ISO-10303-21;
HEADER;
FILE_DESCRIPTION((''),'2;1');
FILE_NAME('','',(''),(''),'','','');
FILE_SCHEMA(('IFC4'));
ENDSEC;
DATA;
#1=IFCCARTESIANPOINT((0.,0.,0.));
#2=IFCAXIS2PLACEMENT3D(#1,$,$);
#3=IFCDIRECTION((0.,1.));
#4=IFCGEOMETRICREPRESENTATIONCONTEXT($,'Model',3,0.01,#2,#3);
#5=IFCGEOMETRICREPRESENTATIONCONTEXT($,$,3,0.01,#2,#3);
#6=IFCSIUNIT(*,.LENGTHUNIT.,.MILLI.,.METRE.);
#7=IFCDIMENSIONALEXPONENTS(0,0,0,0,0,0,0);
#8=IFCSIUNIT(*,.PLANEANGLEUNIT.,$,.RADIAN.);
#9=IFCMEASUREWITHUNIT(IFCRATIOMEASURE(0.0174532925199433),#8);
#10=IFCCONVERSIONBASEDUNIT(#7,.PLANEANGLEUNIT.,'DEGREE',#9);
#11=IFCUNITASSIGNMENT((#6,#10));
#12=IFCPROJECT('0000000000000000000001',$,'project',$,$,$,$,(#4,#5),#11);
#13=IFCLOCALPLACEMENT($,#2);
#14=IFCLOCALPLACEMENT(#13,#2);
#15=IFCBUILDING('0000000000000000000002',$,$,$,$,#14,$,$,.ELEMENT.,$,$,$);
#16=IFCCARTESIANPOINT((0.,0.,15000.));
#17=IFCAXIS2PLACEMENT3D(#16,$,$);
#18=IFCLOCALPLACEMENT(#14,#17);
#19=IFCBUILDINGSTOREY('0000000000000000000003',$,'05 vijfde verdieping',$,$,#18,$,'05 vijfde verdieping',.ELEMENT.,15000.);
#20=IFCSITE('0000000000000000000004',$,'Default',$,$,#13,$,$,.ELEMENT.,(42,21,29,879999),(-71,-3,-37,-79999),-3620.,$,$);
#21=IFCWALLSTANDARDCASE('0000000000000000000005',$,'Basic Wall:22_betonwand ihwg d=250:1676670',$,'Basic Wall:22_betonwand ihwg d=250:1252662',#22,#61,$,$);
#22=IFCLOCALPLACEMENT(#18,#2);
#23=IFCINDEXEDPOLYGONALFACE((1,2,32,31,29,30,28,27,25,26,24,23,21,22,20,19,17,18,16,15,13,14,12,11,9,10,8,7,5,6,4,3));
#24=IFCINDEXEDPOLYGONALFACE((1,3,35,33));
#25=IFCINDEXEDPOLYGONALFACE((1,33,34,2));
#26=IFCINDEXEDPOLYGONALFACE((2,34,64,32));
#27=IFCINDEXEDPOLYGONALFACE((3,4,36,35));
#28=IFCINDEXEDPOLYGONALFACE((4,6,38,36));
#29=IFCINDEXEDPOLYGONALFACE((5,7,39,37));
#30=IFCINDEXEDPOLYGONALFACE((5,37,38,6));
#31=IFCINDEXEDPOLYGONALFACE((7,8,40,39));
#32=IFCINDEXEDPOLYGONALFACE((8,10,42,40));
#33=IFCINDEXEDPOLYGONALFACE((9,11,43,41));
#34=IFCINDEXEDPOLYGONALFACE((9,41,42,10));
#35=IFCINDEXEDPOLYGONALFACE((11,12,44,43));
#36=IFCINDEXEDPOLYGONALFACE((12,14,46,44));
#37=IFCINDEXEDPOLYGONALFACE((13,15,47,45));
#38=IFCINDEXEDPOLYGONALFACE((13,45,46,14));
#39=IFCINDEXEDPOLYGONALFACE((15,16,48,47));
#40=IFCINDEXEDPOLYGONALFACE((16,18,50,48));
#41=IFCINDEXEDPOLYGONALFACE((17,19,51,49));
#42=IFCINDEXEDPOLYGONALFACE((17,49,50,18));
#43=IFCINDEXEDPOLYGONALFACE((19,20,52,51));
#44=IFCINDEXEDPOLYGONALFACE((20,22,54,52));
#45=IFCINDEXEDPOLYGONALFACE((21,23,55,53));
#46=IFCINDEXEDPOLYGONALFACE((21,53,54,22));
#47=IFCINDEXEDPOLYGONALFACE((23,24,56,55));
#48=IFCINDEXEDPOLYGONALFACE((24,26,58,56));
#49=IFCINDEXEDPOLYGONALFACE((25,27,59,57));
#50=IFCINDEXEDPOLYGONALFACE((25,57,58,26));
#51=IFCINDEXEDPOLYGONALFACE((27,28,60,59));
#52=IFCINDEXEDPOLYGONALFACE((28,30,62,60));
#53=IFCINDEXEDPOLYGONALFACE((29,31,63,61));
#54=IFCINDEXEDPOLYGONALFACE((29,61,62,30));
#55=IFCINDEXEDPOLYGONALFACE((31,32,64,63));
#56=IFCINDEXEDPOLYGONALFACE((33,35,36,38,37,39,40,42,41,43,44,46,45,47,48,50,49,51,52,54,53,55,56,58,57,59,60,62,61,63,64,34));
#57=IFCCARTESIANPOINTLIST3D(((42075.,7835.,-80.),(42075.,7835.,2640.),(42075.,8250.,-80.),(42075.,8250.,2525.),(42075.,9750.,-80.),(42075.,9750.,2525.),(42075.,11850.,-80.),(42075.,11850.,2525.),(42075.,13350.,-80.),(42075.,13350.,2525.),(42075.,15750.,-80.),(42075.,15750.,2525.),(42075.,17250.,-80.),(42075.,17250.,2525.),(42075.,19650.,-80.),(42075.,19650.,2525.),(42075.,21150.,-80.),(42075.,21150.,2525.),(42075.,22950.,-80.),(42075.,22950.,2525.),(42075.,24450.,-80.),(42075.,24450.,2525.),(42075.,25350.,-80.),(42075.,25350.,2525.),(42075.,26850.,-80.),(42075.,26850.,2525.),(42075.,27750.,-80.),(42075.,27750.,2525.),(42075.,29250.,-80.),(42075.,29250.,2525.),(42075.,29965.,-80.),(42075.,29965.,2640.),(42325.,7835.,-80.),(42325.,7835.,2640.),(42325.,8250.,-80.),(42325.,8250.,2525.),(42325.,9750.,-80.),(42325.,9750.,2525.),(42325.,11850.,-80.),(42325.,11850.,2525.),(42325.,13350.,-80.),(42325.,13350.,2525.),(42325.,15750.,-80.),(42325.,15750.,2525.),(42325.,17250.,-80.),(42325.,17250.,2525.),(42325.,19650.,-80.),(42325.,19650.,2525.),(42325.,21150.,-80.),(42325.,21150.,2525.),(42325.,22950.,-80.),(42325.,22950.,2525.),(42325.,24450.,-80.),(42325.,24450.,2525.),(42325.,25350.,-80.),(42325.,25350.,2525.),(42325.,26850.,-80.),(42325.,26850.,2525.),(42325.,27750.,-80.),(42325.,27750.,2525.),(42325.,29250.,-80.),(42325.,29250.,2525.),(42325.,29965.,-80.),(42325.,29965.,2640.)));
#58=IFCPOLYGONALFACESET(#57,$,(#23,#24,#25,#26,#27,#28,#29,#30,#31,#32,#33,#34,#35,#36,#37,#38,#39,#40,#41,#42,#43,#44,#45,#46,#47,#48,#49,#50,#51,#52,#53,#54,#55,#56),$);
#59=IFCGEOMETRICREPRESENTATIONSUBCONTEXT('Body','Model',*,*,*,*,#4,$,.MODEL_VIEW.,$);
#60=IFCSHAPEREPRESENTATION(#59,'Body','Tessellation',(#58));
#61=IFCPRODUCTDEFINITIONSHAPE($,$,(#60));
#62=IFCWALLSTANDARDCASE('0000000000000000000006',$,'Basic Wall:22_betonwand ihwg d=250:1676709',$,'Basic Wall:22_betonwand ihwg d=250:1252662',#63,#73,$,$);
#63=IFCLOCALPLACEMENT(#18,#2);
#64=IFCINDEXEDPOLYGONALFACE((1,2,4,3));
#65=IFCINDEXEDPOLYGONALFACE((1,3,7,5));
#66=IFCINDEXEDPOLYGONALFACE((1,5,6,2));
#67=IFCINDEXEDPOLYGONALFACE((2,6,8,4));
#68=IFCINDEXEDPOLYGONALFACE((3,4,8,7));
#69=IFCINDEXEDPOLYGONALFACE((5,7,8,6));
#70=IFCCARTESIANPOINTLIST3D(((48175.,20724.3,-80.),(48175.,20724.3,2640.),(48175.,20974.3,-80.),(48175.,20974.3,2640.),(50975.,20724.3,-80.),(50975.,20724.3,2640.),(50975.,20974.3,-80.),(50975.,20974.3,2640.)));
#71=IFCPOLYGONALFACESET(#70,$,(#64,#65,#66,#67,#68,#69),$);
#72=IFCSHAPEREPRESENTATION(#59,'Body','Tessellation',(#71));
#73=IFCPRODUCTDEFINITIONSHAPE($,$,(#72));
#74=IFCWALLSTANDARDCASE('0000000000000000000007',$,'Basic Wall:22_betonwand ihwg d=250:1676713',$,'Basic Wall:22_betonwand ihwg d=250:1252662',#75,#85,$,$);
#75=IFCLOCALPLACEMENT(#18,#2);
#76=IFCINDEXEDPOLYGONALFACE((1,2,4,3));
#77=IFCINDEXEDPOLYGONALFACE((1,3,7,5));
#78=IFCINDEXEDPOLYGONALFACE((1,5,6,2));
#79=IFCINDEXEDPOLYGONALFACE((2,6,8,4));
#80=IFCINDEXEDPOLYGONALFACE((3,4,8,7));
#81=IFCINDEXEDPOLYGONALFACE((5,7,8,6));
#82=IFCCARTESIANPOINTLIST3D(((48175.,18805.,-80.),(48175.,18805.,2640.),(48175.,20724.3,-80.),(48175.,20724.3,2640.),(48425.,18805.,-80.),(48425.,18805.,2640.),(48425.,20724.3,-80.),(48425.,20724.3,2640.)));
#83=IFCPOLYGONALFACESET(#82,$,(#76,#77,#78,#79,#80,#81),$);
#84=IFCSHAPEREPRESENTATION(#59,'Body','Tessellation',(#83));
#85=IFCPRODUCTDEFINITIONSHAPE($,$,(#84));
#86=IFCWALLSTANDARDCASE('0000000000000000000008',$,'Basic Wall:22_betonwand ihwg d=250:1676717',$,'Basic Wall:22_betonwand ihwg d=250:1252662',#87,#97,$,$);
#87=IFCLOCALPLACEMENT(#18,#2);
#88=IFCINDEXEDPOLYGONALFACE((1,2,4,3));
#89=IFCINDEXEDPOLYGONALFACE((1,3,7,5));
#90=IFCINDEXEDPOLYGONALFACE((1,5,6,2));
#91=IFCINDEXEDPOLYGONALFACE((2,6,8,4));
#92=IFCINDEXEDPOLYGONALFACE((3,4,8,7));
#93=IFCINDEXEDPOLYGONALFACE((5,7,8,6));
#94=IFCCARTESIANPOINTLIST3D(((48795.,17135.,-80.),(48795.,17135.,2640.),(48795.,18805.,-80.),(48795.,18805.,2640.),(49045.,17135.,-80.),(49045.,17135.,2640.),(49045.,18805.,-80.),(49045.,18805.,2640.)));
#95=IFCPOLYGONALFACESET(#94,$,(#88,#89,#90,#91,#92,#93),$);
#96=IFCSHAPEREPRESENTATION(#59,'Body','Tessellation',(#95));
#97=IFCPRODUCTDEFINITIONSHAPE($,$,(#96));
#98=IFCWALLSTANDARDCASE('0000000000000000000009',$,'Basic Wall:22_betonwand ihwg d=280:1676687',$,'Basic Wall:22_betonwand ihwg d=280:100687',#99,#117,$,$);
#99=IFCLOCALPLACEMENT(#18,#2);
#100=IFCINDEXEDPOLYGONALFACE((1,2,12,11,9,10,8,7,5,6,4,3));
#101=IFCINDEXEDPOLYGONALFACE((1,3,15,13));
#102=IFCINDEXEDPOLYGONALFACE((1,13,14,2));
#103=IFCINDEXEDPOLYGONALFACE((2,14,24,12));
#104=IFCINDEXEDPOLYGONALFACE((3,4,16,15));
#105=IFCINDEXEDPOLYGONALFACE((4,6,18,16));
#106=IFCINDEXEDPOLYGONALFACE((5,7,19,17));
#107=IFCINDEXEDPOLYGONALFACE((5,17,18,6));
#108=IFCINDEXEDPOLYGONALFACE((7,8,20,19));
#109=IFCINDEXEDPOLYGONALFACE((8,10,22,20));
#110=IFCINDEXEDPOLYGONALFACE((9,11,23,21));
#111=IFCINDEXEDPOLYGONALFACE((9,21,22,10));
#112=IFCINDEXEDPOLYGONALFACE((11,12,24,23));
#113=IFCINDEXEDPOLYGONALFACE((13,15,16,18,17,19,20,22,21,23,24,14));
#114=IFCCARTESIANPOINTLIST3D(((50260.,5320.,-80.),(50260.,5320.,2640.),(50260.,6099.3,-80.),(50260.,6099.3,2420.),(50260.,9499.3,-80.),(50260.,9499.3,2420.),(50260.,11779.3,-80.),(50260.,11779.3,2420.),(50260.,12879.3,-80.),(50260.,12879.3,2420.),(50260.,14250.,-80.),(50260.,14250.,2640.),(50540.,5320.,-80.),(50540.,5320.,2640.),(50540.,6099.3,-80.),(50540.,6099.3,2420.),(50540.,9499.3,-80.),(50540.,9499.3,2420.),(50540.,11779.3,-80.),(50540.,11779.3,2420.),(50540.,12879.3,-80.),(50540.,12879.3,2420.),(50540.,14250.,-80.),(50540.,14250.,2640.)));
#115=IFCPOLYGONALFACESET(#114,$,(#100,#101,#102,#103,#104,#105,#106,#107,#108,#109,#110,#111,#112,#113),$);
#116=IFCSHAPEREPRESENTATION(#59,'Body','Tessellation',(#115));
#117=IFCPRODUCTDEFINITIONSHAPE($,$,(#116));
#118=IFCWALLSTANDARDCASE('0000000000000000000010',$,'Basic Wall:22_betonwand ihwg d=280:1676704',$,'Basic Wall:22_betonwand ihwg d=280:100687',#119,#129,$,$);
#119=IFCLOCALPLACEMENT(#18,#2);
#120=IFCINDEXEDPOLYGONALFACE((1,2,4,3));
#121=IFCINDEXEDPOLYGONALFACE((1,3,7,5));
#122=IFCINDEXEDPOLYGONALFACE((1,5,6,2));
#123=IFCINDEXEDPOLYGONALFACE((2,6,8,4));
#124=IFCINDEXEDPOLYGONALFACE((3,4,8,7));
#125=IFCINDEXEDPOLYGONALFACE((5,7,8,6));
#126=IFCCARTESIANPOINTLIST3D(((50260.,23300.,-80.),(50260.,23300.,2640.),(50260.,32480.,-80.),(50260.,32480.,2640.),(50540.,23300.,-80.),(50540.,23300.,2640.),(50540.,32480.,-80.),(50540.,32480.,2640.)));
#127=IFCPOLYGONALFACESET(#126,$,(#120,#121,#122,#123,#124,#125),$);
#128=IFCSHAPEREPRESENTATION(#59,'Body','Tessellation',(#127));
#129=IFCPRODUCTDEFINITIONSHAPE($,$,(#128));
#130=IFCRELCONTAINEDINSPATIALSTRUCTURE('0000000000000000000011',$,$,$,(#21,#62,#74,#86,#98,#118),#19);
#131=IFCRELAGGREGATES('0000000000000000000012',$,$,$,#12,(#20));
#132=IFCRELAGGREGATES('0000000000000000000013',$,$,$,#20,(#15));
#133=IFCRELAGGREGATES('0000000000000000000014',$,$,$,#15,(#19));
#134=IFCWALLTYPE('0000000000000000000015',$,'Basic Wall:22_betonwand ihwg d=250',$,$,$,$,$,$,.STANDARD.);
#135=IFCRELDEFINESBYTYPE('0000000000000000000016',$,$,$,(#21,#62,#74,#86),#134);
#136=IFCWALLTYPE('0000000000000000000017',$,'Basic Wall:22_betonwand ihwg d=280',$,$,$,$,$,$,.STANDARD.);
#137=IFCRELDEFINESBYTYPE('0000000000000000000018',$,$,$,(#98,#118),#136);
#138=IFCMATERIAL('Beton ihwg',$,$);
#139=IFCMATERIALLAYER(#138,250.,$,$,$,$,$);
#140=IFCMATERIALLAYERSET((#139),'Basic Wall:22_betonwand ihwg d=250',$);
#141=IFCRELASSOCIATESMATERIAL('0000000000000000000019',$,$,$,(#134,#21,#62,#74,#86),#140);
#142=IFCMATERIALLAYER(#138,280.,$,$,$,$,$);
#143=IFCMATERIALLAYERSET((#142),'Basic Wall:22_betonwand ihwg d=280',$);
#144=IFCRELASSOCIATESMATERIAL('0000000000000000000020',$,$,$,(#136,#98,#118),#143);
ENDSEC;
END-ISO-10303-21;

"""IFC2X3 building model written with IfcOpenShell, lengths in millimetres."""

from ifc_helpers import new_model, entity, si_unit, converted_unit, direction, frame, frame_2d, origin, place, context, subcontext, project, spatial, rectangle, extrude, material, layer, layer_set, layer_usage, type_object, element, save


model = new_model("IFC2X3")

# Units and contexts
model_context = context("Model", 3, precision=0.01, world=origin(), true_north=direction((0.0, 1.0)))
context_of_model = context(None, 3, precision=0.01, world=origin(), true_north=direction((0.0, 1.0)))
body_context = subcontext(model_context, "Body", "Model", "MODEL_VIEW")
ifc_project = project(units=[si_unit("LENGTHUNIT", "METRE", prefix="MILLI"), converted_unit("PLANEANGLEUNIT", "DEGREE", entity("IfcRatioMeasure", 0.0174532925199433), si_unit("PLANEANGLEUNIT", "RADIAN"), dimensions=[0, 0, 0, 0, 0, 0, 0])], contexts=[model_context, context_of_model])

# Site, building, storey
site_placement = place(None, origin())
site = spatial("IfcSite", under=ifc_project, at=site_placement, Name="Default", CompositionType="ELEMENT", RefLatitude=(42, 21, 29, 879999), RefLongitude=(-71, -3, -37, -79999), RefElevation=-3620.0)
building_placement = place(site_placement, origin())
building = spatial("IfcBuilding", under=site, at=building_placement, CompositionType="ELEMENT")
storey_placement = place(building_placement, frame((0.0, 0.0, 15000.0)))
storey = spatial("IfcBuildingStorey", under=building, at=storey_placement, Name="05 vijfde verdieping", LongName="05 vijfde verdieping", CompositionType="ELEMENT", Elevation=15000.0)

# Shared definitions
ifc_material_1 = material(Name="Beton ihwg")

# Wall, openings
ifc_layer_1 = layer(ifc_material_1, 250.0)
ifc_layer_set_1 = layer_set([ifc_layer_1], Name="Basic Wall:22_betonwand ihwg d=250")
ifc_layer_usage_1 = layer_usage(ifc_layer_set_1, "AXIS2", "POSITIVE", -125.0)
wall_type_1 = type_object("IfcWallType", Name="Basic Wall:22_betonwand ihwg d=250", PredefinedType="STANDARD", material=ifc_layer_set_1)
wall_1_placement = place(storey_placement, frame((42200.0, 29965.0, -80.0), z_axis=(0.0, 0.0, 1.0), x_axis=(0.0, -1.0, 0.0)))
wall_1 = element("IfcWallStandardCase", 1, at=wall_1_placement, inside=storey, type_object=wall_type_1, material=ifc_layer_usage_1, Name="Basic Wall:22_betonwand ihwg d=250:1676670", ObjectType="Basic Wall:22_betonwand ihwg d=250:1252662", context=body_context, shape_type="SweptSolid", body=[
    extrude(rectangle(XDim=22130.0, YDim=250.0, at=frame_2d((11065.0, 0.0), x_axis=(-1.0, 0.0))), origin(), (0.0, 0.0, 1.0), 2720.0),
])
opening_1_placement = place(wall_1_placement, frame((29965.0, -42200.0, 80.0), z_axis=(0.0, 0.0, 1.0), x_axis=(0.0, 1.0, 0.0)))
element("IfcOpeningElement", 2, at=opening_1_placement, cuts=wall_1, ObjectType="Opening", context=body_context, shape_type="SweptSolid", body=[
    extrude(rectangle(XDim=2605.0, YDim=1500.0, at=frame_2d((0.0, 0.0), x_axis=(1.0, 0.0))), frame((40801.0, 28500.0, 1222.5), z_axis=(1.0, 0.0, 0.0), x_axis=(0.0, 0.0, -1.0)), (0.0, 0.0, 1.0), 3048.0),
])
opening_2_placement = place(wall_1_placement, frame((29965.0, -42200.0, 80.0), z_axis=(0.0, 0.0, 1.0), x_axis=(0.0, 1.0, 0.0)))
element("IfcOpeningElement", 3, at=opening_2_placement, cuts=wall_1, ObjectType="Opening", context=body_context, shape_type="SweptSolid", body=[
    extrude(rectangle(XDim=2605.0, YDim=1500.0, at=frame_2d((0.0, 0.0), x_axis=(1.0, 0.0))), frame((40801.0, 26100.0, 1222.5), z_axis=(1.0, 0.0, 0.0), x_axis=(0.0, 0.0, -1.0)), (0.0, 0.0, 1.0), 3048.0),
])
opening_3_placement = place(wall_1_placement, frame((29965.0, -42200.0, 80.0), z_axis=(0.0, 0.0, 1.0), x_axis=(0.0, 1.0, 0.0)))
element("IfcOpeningElement", 4, at=opening_3_placement, cuts=wall_1, ObjectType="Opening", context=body_context, shape_type="SweptSolid", body=[
    extrude(rectangle(XDim=2605.0, YDim=1500.0, at=frame_2d((0.0, 0.0), x_axis=(1.0, 0.0))), frame((40801.0, 23700.0, 1222.5), z_axis=(1.0, 0.0, 0.0), x_axis=(0.0, 0.0, -1.0)), (0.0, 0.0, 1.0), 3048.0),
])
opening_4_placement = place(wall_1_placement, frame((29965.0, -42200.0, 80.0), z_axis=(0.0, 0.0, 1.0), x_axis=(0.0, 1.0, 0.0)))
element("IfcOpeningElement", 5, at=opening_4_placement, cuts=wall_1, ObjectType="Opening", context=body_context, shape_type="SweptSolid", body=[
    extrude(rectangle(XDim=2605.0, YDim=1500.0, at=frame_2d((0.0, 0.0), x_axis=(1.0, 0.0))), frame((40801.0, 20400.0, 1222.5), z_axis=(1.0, 0.0, 0.0), x_axis=(0.0, 0.0, -1.0)), (0.0, 0.0, 1.0), 3048.0),
])
opening_5_placement = place(wall_1_placement, frame((29965.0, -42200.0, 80.0), z_axis=(0.0, 0.0, 1.0), x_axis=(0.0, 1.0, 0.0)))
element("IfcOpeningElement", 6, at=opening_5_placement, cuts=wall_1, ObjectType="Opening", context=body_context, shape_type="SweptSolid", body=[
    extrude(rectangle(XDim=2605.0, YDim=1500.0, at=frame_2d((0.0, 0.0), x_axis=(1.0, 0.0))), frame((40801.0, 12600.0, 1222.5), z_axis=(1.0, 0.0, 0.0), x_axis=(0.0, 0.0, -1.0)), (0.0, 0.0, 1.0), 3048.0),
])
opening_6_placement = place(wall_1_placement, frame((29965.0, -42200.0, -2920.0), z_axis=(0.0, 0.0, 1.0), x_axis=(0.0, 1.0, 0.0)))
element("IfcOpeningElement", 7, at=opening_6_placement, cuts=wall_1, ObjectType="Opening", context=body_context, shape_type="SweptSolid", body=[
    extrude(rectangle(XDim=2605.0, YDim=1500.0, at=frame_2d((0.0, 0.0), x_axis=(1.0, 0.0))), frame((40801.0, 9000.0, 4222.5), z_axis=(1.0, 0.0, 0.0), x_axis=(0.0, 0.0, -1.0)), (0.0, 0.0, 1.0), 3048.0),
])
opening_7_placement = place(wall_1_placement, frame((29965.0, -42200.0, 80.0), z_axis=(0.0, 0.0, 1.0), x_axis=(0.0, 1.0, 0.0)))
element("IfcOpeningElement", 8, at=opening_7_placement, cuts=wall_1, ObjectType="Opening", context=body_context, shape_type="SweptSolid", body=[
    extrude(rectangle(XDim=2605.0, YDim=1500.0, at=frame_2d((0.0, 0.0), x_axis=(0.0, 1.0))), frame((40551.0, 16500.0, 1222.5), z_axis=(1.0, 0.0, 0.0), x_axis=(0.0, -1.0, 0.0)), (0.0, 0.0, 1.0), 3048.0),
])

# Walls
ifc_layer_usage_2 = layer_usage(ifc_layer_set_1, "AXIS2", "POSITIVE", -125.0)
wall_2_placement = place(storey_placement, frame((50975.0, 20849.3, -80.0), z_axis=(0.0, 0.0, 1.0), x_axis=(-1.0, 0.0, 0.0)))
element("IfcWallStandardCase", 9, at=wall_2_placement, inside=storey, type_object=wall_type_1, material=ifc_layer_usage_2, Name="Basic Wall:22_betonwand ihwg d=250:1676709", ObjectType="Basic Wall:22_betonwand ihwg d=250:1252662", context=body_context, shape_type="SweptSolid", body=[
    extrude(rectangle(XDim=2800.0, YDim=250.0, at=frame_2d((1400.0, 0.0), x_axis=(-1.0, 0.0))), origin(), (0.0, 0.0, 1.0), 2720.0),
])
ifc_layer_usage_3 = layer_usage(ifc_layer_set_1, "AXIS2", "POSITIVE", -125.0)
wall_3_placement = place(storey_placement, frame((48300.0, 20724.3, -80.0), z_axis=(0.0, 0.0, 1.0), x_axis=(0.0, -1.0, 0.0)))
element("IfcWallStandardCase", 10, at=wall_3_placement, inside=storey, type_object=wall_type_1, material=ifc_layer_usage_3, Name="Basic Wall:22_betonwand ihwg d=250:1676713", ObjectType="Basic Wall:22_betonwand ihwg d=250:1252662", context=body_context, shape_type="SweptSolid", body=[
    extrude(rectangle(XDim=1919.3, YDim=250.0, at=frame_2d((959.6, 0.0), x_axis=(-1.0, 0.0))), origin(), (0.0, 0.0, 1.0), 2720.0),
])
ifc_layer_usage_4 = layer_usage(ifc_layer_set_1, "AXIS2", "POSITIVE", -125.0)
wall_4_placement = place(storey_placement, frame((48920.0, 18805.0, -80.0), z_axis=(0.0, 0.0, 1.0), x_axis=(0.0, -1.0, 0.0)))
element("IfcWallStandardCase", 11, at=wall_4_placement, inside=storey, type_object=wall_type_1, material=ifc_layer_usage_4, Name="Basic Wall:22_betonwand ihwg d=250:1676717", ObjectType="Basic Wall:22_betonwand ihwg d=250:1252662", context=body_context, shape_type="SweptSolid", body=[
    extrude(rectangle(XDim=1670.0, YDim=250.0, at=frame_2d((835.0, 0.0), x_axis=(-1.0, 0.0))), origin(), (0.0, 0.0, 1.0), 2720.0),
])

# Wall, openings
ifc_layer_2 = layer(ifc_material_1, 280.0)
ifc_layer_set_2 = layer_set([ifc_layer_2], Name="Basic Wall:22_betonwand ihwg d=280")
ifc_layer_usage_5 = layer_usage(ifc_layer_set_2, "AXIS2", "NEGATIVE", 140.0)
wall_type_2 = type_object("IfcWallType", Name="Basic Wall:22_betonwand ihwg d=280", PredefinedType="STANDARD", material=ifc_layer_set_2)
wall_5_placement = place(storey_placement, frame((50400.0, 14250.0, -80.0), z_axis=(0.0, 0.0, 1.0), x_axis=(0.0, -1.0, 0.0)))
wall_5 = element("IfcWallStandardCase", 12, at=wall_5_placement, inside=storey, type_object=wall_type_2, material=ifc_layer_usage_5, Name="Basic Wall:22_betonwand ihwg d=280:1676687", ObjectType="Basic Wall:22_betonwand ihwg d=280:100687", context=body_context, shape_type="SweptSolid", body=[
    extrude(rectangle(XDim=8930.0, YDim=280.0, at=frame_2d((4465.0, 0.0), x_axis=(-1.0, 0.0))), origin(), (0.0, 0.0, 1.0), 2720.0),
])
opening_8_placement = place(wall_5_placement, frame((14250.0, -50400.0, 80.0), z_axis=(0.0, 0.0, 1.0), x_axis=(0.0, 1.0, 0.0)))
element("IfcOpeningElement", 13, at=opening_8_placement, cuts=wall_5, ObjectType="Opening", context=body_context, shape_type="SweptSolid", body=[
    extrude(rectangle(XDim=2500.0, YDim=3400.0, at=frame_2d((0.0, 0.0), x_axis=(1.0, 0.0))), frame((50000.0, 7799.3, 1170.0), z_axis=(1.0, 0.0, 0.0), x_axis=(0.0, 0.0, -1.0)), (0.0, 0.0, 1.0), 800.0),
])
opening_9_placement = place(wall_5_placement, frame((14250.0, -50400.0, 80.0), z_axis=(0.0, 0.0, 1.0), x_axis=(0.0, 1.0, 0.0)))
element("IfcOpeningElement", 14, at=opening_9_placement, cuts=wall_5, ObjectType="Opening", context=body_context, shape_type="SweptSolid", body=[
    extrude(rectangle(XDim=2500.0, YDim=1100.0, at=frame_2d((0.0, 0.0), x_axis=(0.0, 1.0))), frame((50000.0, 12329.3, 1170.0), z_axis=(1.0, 0.0, 0.0), x_axis=(0.0, -1.0, 0.0)), (0.0, 0.0, 1.0), 800.0),
])

# Wall
ifc_layer_usage_6 = layer_usage(ifc_layer_set_2, "AXIS2", "POSITIVE", -140.0)
wall_6_placement = place(storey_placement, frame((50400.0, 23300.0, -80.0), z_axis=(0.0, 0.0, 1.0), x_axis=(0.0, 1.0, 0.0)))
element("IfcWallStandardCase", 15, at=wall_6_placement, inside=storey, type_object=wall_type_2, material=ifc_layer_usage_6, Name="Basic Wall:22_betonwand ihwg d=280:1676704", ObjectType="Basic Wall:22_betonwand ihwg d=280:100687", context=body_context, shape_type="SweptSolid", body=[
    extrude(rectangle(XDim=9180.0, YDim=280.0, at=frame_2d((4590.0, 0.0), x_axis=(-1.0, 0.0))), origin(), (0.0, 0.0, 1.0), 2720.0),
])

save(model, "model.ifc")
